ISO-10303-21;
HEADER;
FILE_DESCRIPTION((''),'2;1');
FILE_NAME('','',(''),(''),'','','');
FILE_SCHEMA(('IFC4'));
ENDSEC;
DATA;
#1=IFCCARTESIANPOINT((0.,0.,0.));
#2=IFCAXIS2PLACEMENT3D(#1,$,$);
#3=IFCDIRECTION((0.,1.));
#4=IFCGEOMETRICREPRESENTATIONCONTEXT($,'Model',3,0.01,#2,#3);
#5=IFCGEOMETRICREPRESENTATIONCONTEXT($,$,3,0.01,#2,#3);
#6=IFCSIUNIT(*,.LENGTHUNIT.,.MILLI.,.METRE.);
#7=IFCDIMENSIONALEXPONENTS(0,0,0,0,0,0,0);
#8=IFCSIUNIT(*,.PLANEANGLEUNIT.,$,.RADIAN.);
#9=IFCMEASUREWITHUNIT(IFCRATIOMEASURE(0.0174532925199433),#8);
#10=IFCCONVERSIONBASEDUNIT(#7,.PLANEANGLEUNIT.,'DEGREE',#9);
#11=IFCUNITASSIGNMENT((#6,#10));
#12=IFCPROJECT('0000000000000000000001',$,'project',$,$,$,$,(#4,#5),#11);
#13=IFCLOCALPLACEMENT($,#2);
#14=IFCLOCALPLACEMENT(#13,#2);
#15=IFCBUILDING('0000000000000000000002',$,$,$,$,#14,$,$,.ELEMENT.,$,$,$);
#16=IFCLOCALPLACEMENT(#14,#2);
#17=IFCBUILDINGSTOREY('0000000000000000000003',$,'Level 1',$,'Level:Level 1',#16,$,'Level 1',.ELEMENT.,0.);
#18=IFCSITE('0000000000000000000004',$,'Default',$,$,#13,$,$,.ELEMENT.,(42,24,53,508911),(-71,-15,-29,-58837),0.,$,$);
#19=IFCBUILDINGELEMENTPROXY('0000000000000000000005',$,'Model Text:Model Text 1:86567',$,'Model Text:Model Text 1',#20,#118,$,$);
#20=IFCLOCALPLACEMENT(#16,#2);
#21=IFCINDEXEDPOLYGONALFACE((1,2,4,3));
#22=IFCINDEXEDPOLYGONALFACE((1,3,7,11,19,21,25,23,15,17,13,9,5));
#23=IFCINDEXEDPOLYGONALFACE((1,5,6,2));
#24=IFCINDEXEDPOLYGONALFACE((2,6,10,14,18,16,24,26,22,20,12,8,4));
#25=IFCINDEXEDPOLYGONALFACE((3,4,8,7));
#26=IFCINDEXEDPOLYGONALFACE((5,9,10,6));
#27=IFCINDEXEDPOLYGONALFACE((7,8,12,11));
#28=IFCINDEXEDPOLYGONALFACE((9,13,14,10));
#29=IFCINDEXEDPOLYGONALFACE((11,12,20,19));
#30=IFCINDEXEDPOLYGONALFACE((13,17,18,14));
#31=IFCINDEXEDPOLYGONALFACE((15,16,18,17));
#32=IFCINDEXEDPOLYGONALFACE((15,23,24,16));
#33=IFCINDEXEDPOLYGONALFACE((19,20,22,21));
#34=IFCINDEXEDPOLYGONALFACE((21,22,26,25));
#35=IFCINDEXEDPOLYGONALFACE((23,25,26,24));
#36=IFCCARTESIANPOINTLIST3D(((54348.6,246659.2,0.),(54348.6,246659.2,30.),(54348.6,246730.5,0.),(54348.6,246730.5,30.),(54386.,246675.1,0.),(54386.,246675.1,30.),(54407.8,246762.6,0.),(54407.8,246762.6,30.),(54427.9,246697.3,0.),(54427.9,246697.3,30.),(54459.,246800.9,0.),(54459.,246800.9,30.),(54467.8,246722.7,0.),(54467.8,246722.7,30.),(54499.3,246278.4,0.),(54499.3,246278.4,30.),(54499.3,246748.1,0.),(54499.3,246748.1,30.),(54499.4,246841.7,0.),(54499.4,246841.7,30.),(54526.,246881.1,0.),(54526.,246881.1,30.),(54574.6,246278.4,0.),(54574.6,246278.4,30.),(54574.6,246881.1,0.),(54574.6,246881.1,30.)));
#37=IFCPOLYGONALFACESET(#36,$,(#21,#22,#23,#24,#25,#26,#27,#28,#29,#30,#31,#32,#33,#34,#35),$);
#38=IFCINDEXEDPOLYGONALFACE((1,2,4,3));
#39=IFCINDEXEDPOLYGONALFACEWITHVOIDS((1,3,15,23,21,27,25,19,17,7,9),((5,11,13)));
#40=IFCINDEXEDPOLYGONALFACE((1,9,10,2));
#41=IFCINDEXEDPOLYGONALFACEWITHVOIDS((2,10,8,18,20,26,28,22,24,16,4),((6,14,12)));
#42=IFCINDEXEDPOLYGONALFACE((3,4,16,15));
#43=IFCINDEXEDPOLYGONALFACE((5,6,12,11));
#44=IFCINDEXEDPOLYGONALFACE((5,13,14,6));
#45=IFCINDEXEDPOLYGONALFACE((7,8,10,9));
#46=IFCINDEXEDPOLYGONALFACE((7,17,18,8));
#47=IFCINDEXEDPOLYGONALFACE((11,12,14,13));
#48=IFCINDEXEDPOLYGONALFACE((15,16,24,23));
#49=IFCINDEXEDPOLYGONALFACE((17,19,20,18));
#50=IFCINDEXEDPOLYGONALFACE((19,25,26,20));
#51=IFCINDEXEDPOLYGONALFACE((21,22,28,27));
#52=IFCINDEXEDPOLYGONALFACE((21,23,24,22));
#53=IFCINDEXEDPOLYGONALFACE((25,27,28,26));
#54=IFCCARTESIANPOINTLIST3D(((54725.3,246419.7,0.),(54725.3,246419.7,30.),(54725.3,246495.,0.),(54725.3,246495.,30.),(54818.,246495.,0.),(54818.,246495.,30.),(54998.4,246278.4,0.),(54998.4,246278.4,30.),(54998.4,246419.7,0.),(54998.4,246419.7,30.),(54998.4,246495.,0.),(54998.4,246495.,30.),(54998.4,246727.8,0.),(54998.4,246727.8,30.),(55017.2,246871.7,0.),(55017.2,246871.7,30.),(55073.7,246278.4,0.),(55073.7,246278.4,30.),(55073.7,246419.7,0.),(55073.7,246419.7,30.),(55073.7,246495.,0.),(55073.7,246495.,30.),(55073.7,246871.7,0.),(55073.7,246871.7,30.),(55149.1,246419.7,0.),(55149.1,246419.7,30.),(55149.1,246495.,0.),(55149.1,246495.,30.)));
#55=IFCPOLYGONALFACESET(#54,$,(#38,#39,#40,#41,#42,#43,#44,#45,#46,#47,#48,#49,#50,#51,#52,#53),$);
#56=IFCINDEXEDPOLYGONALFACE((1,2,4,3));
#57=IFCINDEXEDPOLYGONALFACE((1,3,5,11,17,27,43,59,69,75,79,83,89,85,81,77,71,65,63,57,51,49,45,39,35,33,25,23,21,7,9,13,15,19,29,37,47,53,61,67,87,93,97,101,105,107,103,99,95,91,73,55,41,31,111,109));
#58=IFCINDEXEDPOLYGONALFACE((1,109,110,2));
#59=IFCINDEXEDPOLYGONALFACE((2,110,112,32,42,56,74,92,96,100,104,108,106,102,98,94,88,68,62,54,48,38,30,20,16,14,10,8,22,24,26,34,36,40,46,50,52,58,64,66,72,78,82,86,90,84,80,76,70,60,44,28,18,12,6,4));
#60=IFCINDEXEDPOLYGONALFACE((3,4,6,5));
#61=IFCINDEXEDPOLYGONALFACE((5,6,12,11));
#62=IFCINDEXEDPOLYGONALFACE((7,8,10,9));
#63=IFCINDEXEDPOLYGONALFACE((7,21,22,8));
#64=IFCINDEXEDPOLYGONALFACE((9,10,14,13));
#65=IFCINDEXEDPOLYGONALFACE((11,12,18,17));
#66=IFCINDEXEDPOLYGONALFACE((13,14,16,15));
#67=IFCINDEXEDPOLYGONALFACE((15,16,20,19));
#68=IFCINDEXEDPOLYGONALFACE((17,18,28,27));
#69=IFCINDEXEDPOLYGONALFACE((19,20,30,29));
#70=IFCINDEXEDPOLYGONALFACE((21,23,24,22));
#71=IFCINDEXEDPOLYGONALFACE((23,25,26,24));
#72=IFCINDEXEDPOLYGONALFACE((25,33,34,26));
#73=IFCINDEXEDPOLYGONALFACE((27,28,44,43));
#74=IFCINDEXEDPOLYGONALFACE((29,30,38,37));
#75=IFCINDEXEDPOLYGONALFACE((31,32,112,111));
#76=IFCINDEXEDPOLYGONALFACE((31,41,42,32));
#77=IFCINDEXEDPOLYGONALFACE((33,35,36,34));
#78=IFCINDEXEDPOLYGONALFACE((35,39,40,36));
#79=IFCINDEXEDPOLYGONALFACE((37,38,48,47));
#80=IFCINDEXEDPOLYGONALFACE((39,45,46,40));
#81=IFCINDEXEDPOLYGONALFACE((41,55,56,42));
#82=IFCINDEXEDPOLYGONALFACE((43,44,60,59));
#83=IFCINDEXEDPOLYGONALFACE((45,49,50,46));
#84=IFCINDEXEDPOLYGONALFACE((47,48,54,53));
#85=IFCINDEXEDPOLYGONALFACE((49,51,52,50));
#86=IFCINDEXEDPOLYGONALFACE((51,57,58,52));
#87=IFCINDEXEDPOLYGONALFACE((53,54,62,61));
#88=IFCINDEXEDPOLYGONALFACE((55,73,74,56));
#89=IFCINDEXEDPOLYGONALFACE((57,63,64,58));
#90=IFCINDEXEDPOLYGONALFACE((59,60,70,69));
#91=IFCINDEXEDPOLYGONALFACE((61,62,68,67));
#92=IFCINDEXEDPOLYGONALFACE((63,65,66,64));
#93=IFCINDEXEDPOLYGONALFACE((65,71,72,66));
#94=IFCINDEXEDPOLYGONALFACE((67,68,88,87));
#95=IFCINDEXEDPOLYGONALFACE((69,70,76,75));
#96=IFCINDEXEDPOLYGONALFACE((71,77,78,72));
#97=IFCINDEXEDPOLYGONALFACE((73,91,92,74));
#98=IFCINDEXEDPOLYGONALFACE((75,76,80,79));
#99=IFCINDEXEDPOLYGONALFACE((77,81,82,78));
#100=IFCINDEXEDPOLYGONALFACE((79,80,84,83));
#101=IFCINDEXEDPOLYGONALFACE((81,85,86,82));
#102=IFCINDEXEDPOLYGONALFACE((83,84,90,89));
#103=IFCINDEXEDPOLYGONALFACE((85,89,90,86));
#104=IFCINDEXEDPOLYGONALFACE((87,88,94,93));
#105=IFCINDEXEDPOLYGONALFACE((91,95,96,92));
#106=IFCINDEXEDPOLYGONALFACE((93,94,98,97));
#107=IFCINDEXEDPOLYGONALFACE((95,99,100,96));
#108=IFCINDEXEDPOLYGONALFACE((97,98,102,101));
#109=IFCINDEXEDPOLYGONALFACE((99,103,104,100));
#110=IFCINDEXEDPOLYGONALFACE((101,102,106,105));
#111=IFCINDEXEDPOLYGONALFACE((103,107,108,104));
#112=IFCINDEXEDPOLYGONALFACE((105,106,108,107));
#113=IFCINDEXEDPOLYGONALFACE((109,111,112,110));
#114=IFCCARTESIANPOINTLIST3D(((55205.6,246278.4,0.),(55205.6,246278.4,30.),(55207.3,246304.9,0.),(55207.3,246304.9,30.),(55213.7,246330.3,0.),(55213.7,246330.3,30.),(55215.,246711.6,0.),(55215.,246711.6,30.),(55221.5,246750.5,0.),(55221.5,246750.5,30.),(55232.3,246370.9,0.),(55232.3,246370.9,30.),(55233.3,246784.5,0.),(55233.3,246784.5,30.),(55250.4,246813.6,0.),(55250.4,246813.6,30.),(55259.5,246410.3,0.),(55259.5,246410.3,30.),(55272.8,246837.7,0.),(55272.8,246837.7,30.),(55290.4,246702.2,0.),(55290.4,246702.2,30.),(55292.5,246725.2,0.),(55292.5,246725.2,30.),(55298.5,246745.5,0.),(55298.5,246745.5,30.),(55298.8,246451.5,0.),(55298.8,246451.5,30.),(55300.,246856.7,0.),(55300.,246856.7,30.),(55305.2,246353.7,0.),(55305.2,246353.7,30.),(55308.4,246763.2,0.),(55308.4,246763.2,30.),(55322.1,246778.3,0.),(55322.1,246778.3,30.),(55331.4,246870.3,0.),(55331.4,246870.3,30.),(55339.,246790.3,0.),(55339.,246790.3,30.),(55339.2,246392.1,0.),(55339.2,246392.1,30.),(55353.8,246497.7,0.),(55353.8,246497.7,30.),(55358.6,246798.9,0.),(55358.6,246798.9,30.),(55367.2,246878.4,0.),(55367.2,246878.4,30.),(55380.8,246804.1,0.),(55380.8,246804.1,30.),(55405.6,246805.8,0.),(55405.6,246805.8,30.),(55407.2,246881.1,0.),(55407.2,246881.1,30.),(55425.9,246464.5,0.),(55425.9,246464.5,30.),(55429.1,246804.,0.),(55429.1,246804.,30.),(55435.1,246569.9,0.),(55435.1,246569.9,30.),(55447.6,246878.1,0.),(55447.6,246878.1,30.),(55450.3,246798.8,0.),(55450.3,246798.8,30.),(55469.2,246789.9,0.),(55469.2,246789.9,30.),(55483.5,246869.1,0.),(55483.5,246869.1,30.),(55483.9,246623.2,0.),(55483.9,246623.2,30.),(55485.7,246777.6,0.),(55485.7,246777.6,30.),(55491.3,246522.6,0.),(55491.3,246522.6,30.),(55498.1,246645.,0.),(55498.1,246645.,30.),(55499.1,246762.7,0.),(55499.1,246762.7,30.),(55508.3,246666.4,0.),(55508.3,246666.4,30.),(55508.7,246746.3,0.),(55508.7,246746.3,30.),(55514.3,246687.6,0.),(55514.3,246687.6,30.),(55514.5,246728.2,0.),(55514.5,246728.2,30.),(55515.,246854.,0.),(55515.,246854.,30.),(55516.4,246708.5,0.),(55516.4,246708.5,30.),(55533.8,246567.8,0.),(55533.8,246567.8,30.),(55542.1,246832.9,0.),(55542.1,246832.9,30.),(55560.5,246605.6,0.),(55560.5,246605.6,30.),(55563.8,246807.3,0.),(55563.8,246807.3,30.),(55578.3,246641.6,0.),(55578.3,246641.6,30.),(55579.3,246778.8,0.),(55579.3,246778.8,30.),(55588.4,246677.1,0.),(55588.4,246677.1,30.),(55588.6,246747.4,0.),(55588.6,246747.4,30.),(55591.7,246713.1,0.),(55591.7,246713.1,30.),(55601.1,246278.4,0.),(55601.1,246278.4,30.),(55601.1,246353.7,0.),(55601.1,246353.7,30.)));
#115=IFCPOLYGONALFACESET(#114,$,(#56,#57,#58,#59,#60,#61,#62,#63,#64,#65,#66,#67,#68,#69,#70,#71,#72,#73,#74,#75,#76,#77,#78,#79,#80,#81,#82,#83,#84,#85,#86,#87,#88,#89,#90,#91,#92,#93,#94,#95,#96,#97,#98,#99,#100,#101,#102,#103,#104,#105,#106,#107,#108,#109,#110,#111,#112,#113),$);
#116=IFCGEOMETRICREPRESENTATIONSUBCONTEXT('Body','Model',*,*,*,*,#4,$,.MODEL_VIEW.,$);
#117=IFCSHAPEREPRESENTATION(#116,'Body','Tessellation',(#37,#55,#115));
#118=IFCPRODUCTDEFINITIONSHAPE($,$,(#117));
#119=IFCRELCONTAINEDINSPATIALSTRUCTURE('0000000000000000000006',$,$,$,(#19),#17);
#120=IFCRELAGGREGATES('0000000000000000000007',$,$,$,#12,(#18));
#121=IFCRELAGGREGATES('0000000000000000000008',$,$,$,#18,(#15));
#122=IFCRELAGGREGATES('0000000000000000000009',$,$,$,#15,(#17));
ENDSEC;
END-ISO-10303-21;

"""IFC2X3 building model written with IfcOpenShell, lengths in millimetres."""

from ifc_helpers import new_model, entity, si_unit, converted_unit, direction, frame, origin, place, context, subcontext, project, spatial, polyline, outline, extrude, element, save


model = new_model("IFC2X3")

# Units and contexts
model_context = context("Model", 3, precision=0.01, world=origin(), true_north=direction((0.0, 1.0)))
context_of_model = context(None, 3, precision=0.01, world=origin(), true_north=direction((0.0, 1.0)))
body_context = subcontext(model_context, "Body", "Model", "MODEL_VIEW")
ifc_project = project(units=[si_unit("LENGTHUNIT", "METRE", prefix="MILLI"), converted_unit("PLANEANGLEUNIT", "DEGREE", entity("IfcRatioMeasure", 0.0174532925199433), si_unit("PLANEANGLEUNIT", "RADIAN"), dimensions=[0, 0, 0, 0, 0, 0, 0])], contexts=[model_context, context_of_model])

# Site, building, storey
site_placement = place(None, origin())
site = spatial("IfcSite", under=ifc_project, at=site_placement, Name="Default", CompositionType="ELEMENT", RefLatitude=(42, 24, 53, 508911), RefLongitude=(-71, -15, -29, -58837), RefElevation=0.0)
building_placement = place(site_placement, origin())
building = spatial("IfcBuilding", under=site, at=building_placement, CompositionType="ELEMENT")
storey_placement = place(building_placement, origin())
storey = spatial("IfcBuildingStorey", under=building, at=storey_placement, Name="Level 1", ObjectType="Level:Level 1", LongName="Level 1", CompositionType="ELEMENT", Elevation=0.0)

# Building element proxy
proxy_1_placement = place(storey_placement, origin())
element("IfcBuildingElementProxy", 1, at=proxy_1_placement, inside=storey, Name="Model Text:Model Text 1:86567", ObjectType="Model Text:Model Text 1", context=body_context, shape_type="SweptSolid", body=[
    extrude(outline(polyline([(-410.6, -111.6), (192.1, -111.6), (192.1, -63.1), (152.7, -36.4), (111.9, 4.0), (73.6, 55.2), (41.4, 114.4), (-29.8, 114.4), (-13.9, 77.0), (8.3, 35.1), (33.7, -4.8), (59.1, -36.3), (-410.6, -36.3), (-410.6, -111.6)])), frame((54463.0, 246689.0, 0.0), z_axis=(0.0, 0.0, 1.0), x_axis=(0.0, 1.0, 0.0)), (0.0, 0.0, 1.0), 30.0),
    extrude(outline(polyline([(-6.8, -218.3), (68.5, -218.3), (68.5, -77.1), (143.8, -77.1), (143.8, -1.7), (68.5, -1.7), (68.5, 375.0), (12.0, 375.0), (-280.0, -1.7), (-280.0, -77.1), (-6.8, -77.1), (-6.8, -218.3)]), holes=[polyline([(-6.8, -1.7), (-187.3, -1.7), (-6.8, 231.1), (-6.8, -1.7)])]), frame((55005.3, 246496.7, 0.0)), (0.0, 0.0, 1.0), 30.0),
    extrude(outline(polyline([(-190.2, -317.5), (-190.2, -392.8), (205.4, -392.8), (203.7, -366.3), (197.3, -340.9), (178.7, -300.3), (151.5, -260.9), (112.2, -219.7), (57.2, -173.6), (-24.1, -101.3), (-72.9, -48.0), (-87.1, -26.3), (-97.3, -4.8), (-103.4, 16.4), (-105.4, 37.3), (-103.5, 57.0), (-97.7, 75.0), (-88.2, 91.5), (-74.7, 106.4), (-58.2, 118.7), (-39.4, 127.5), (-18.2, 132.8), (5.4, 134.6), (30.2, 132.9), (52.4, 127.7), (72.0, 119.1), (88.9, 107.1), (102.6, 92.0), (112.5, 74.3), (118.5, 54.0), (120.6, 31.0), (196.0, 40.4), (189.5, 79.3), (177.7, 113.3), (160.6, 142.4), (138.2, 166.5), (111.0, 185.5), (79.5, 199.1), (43.8, 207.2), (3.8, 209.9), (-36.6, 206.9), (-72.5, 197.9), (-104.0, 182.8), (-131.1, 161.7), (-152.8, 136.1), (-168.3, 107.6), (-177.6, 76.2), (-180.8, 41.9), (-177.4, 5.8), (-167.4, -29.6), (-149.5, -65.6), (-122.8, -103.4), (-80.3, -148.6), (-14.9, -206.7), (71.8, -279.1), (105.8, -317.5), (-190.2, -317.5)])), frame((55411.0, 246671.2, 0.0), z_axis=(0.0, 0.0, -1.0), x_axis=(-1.0, 0.0, 0.0)), (0.0, 0.0, -1.0), 30.0),
])

save(model, "model.ifc")
